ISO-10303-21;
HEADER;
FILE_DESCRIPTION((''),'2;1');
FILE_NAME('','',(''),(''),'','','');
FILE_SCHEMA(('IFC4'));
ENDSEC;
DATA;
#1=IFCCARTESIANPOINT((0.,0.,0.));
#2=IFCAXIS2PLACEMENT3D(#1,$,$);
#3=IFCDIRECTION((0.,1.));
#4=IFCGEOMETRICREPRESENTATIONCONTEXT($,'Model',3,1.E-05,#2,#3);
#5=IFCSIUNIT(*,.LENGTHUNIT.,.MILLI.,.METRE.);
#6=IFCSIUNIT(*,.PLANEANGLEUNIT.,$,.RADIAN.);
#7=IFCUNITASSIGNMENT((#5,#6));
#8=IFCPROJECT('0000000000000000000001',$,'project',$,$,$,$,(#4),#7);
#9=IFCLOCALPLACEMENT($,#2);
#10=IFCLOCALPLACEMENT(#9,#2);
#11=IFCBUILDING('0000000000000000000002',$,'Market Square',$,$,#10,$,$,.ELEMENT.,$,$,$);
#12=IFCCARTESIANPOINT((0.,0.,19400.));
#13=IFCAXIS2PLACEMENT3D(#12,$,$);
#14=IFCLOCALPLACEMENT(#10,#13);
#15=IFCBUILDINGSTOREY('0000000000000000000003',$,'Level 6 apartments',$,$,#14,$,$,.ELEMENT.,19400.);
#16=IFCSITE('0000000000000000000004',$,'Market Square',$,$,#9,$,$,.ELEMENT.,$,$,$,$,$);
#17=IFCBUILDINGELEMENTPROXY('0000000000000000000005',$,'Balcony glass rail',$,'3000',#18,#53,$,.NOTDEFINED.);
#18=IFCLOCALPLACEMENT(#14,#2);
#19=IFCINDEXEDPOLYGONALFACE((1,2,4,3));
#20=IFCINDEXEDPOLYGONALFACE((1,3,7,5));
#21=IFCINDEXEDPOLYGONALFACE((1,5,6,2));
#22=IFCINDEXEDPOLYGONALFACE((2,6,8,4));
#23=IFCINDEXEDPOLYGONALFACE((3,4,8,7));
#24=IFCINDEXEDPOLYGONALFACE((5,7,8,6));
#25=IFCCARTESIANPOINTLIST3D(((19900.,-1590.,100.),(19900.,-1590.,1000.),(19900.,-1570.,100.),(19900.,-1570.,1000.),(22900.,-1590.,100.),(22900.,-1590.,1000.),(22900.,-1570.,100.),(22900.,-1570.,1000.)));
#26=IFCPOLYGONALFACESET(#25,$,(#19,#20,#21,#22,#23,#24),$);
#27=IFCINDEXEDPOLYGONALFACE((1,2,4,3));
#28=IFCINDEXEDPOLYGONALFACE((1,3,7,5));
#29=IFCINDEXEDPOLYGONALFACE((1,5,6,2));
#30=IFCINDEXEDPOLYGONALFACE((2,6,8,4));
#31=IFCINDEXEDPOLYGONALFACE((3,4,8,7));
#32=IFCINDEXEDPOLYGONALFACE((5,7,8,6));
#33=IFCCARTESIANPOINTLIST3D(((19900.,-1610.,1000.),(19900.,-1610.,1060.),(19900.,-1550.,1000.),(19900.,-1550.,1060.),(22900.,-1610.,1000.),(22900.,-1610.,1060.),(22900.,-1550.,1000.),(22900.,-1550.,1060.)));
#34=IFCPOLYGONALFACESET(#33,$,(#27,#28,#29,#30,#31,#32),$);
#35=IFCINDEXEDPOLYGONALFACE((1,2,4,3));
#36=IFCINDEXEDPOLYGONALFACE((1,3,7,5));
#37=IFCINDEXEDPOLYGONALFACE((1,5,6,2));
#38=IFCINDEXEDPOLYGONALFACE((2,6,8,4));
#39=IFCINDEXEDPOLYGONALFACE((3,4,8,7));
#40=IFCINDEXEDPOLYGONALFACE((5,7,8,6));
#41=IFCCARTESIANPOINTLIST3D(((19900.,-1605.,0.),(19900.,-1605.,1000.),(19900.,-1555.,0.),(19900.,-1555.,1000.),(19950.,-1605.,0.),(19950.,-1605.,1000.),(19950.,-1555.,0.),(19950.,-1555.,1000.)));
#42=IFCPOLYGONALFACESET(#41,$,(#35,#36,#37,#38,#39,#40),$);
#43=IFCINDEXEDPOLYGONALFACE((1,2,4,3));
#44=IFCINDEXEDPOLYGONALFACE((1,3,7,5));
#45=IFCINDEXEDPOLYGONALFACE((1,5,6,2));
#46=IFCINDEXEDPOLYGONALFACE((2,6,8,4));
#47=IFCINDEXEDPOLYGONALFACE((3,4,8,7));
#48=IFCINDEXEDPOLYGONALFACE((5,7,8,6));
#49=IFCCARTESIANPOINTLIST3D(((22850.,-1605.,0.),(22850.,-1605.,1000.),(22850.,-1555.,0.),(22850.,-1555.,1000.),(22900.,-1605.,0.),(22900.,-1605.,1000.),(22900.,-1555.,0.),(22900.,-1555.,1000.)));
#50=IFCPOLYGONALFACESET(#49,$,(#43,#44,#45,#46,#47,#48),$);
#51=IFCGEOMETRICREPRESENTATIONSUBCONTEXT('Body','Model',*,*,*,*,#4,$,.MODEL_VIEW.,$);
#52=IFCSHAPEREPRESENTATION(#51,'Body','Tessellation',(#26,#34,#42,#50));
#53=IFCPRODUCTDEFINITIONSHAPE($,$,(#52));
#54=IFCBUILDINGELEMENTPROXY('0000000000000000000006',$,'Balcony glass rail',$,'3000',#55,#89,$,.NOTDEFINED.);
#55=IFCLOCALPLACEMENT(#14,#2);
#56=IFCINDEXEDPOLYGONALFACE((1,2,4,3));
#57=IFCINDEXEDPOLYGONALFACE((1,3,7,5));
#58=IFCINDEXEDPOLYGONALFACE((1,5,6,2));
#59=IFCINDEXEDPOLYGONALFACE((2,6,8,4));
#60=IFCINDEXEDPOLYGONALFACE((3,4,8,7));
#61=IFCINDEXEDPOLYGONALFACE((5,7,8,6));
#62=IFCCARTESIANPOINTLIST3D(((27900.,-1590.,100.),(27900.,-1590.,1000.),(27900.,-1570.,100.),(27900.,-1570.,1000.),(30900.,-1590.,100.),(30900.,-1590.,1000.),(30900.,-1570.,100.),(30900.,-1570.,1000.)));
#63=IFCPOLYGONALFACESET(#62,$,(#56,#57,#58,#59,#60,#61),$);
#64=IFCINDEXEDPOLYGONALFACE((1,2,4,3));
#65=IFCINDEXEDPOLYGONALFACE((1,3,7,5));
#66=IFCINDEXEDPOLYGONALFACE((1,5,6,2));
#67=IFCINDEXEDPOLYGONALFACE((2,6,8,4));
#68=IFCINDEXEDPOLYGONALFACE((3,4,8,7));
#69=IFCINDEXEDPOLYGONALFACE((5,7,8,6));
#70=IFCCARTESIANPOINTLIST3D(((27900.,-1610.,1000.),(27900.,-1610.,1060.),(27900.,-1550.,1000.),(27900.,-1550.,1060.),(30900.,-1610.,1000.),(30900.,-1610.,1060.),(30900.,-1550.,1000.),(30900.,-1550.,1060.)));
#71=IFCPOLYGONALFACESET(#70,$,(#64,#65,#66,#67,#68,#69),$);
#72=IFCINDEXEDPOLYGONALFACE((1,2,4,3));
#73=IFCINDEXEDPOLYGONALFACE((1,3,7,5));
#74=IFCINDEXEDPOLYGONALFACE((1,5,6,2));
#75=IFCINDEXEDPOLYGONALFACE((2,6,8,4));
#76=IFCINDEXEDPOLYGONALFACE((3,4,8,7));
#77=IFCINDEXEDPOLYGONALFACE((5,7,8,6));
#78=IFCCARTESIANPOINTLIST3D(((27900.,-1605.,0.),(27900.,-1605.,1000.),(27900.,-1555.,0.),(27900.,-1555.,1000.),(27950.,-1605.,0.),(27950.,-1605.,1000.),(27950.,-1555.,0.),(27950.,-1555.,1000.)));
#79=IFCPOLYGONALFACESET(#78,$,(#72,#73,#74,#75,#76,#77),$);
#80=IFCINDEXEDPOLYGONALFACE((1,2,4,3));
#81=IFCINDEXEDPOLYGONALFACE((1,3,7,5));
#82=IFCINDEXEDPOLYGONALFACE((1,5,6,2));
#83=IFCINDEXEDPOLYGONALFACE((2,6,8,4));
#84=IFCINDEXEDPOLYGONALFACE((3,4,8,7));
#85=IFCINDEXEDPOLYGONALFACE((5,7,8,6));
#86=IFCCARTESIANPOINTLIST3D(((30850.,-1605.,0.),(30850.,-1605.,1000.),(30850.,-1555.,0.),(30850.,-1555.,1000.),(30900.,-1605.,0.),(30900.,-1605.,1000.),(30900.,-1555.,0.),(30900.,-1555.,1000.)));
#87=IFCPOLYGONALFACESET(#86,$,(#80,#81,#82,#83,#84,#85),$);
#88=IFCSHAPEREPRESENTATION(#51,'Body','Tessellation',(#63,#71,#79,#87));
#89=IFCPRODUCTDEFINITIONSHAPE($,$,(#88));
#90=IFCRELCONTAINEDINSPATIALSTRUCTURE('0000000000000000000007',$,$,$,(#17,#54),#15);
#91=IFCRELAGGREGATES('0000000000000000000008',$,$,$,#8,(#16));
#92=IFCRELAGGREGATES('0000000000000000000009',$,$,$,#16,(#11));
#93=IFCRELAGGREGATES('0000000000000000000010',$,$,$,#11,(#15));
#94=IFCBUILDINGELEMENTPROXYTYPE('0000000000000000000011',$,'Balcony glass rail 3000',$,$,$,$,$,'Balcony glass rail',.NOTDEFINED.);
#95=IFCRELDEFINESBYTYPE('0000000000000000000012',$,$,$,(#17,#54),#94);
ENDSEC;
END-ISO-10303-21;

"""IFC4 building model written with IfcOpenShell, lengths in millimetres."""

from ifc_helpers import new_model, si_unit, direction, frame, origin, place, context, subcontext, project, spatial, polyline, outline, extrude, source, transform, mapped, type_object, type_shapes, element, save


model = new_model("IFC4")

# Units and contexts
model_context = context("Model", 3, precision=1e-05, world=origin(), true_north=direction((0.0, 1.0)))
body_context = subcontext(model_context, "Body", "Model", "MODEL_VIEW")
ifc_project = project(units=[si_unit("LENGTHUNIT", "METRE", prefix="MILLI"), si_unit("PLANEANGLEUNIT", "RADIAN")], contexts=[model_context])

# Site, building, storey
site_placement = place(None, origin())
site = spatial("IfcSite", under=ifc_project, at=site_placement, Name="Market Square", CompositionType="ELEMENT")
building_placement = place(site_placement, origin())
building = spatial("IfcBuilding", under=site, at=building_placement, Name="Market Square", CompositionType="ELEMENT")
storey_placement = place(building_placement, frame((0.0, 0.0, 19400.0)))
storey = spatial("IfcBuildingStorey", under=building, at=storey_placement, Name="Level 6 apartments", CompositionType="ELEMENT", Elevation=19400.0)

# Building element proxies
building_element_proxy_type = type_object("IfcBuildingElementProxyType", Name="Balcony glass rail 3000", ElementType="Balcony glass rail", PredefinedType="NOTDEFINED")
shared_shape = source(origin(), body_context, "Body", "SweptSolid", [
    extrude(outline(polyline([(0.0, -10.0), (3000.0, -10.0), (3000.0, 10.0), (0.0, 10.0), (0.0, -10.0)])), frame((0.0, 0.0, 100.0)), (0.0, 0.0, 1.0), 900.0),
    extrude(outline(polyline([(0.0, -30.0), (3000.0, -30.0), (3000.0, 30.0), (0.0, 30.0), (0.0, -30.0)])), frame((0.0, 0.0, 1000.0)), (0.0, 0.0, 1.0), 60.0),
    extrude(outline(polyline([(0.0, -25.0), (50.0, -25.0), (50.0, 25.0), (0.0, 25.0), (0.0, -25.0)])), origin(), (0.0, 0.0, 1.0), 1000.0),
    extrude(outline(polyline([(2950.0, -25.0), (3000.0, -25.0), (3000.0, 25.0), (2950.0, 25.0), (2950.0, -25.0)])), origin(), (0.0, 0.0, 1.0), 1000.0),
])
type_shapes(building_element_proxy_type, [shared_shape])
for number, where, z_axis, x_axis, name in (
    (1, (19900.0, -1580.0, 0.0), (0.0, 0.0, 1.0), (1.0, 0.0, 0.0), "Balcony glass rail"),
    (2, (27900.0, -1580.0, 0.0), (0.0, 0.0, 1.0), (1.0, 0.0, 0.0), "Balcony glass rail"),
):
    element("IfcBuildingElementProxy", number, at=place(storey_placement, frame(where, z_axis=z_axis, x_axis=x_axis)), inside=storey, type_object=building_element_proxy_type, Name=name, ObjectType="3000", PredefinedType="NOTDEFINED", context=body_context, shape_type="MappedRepresentation", body=[
        mapped(shared_shape, transform((0.0, 0.0, 0.0))),
    ])

save(model, "model.ifc")
